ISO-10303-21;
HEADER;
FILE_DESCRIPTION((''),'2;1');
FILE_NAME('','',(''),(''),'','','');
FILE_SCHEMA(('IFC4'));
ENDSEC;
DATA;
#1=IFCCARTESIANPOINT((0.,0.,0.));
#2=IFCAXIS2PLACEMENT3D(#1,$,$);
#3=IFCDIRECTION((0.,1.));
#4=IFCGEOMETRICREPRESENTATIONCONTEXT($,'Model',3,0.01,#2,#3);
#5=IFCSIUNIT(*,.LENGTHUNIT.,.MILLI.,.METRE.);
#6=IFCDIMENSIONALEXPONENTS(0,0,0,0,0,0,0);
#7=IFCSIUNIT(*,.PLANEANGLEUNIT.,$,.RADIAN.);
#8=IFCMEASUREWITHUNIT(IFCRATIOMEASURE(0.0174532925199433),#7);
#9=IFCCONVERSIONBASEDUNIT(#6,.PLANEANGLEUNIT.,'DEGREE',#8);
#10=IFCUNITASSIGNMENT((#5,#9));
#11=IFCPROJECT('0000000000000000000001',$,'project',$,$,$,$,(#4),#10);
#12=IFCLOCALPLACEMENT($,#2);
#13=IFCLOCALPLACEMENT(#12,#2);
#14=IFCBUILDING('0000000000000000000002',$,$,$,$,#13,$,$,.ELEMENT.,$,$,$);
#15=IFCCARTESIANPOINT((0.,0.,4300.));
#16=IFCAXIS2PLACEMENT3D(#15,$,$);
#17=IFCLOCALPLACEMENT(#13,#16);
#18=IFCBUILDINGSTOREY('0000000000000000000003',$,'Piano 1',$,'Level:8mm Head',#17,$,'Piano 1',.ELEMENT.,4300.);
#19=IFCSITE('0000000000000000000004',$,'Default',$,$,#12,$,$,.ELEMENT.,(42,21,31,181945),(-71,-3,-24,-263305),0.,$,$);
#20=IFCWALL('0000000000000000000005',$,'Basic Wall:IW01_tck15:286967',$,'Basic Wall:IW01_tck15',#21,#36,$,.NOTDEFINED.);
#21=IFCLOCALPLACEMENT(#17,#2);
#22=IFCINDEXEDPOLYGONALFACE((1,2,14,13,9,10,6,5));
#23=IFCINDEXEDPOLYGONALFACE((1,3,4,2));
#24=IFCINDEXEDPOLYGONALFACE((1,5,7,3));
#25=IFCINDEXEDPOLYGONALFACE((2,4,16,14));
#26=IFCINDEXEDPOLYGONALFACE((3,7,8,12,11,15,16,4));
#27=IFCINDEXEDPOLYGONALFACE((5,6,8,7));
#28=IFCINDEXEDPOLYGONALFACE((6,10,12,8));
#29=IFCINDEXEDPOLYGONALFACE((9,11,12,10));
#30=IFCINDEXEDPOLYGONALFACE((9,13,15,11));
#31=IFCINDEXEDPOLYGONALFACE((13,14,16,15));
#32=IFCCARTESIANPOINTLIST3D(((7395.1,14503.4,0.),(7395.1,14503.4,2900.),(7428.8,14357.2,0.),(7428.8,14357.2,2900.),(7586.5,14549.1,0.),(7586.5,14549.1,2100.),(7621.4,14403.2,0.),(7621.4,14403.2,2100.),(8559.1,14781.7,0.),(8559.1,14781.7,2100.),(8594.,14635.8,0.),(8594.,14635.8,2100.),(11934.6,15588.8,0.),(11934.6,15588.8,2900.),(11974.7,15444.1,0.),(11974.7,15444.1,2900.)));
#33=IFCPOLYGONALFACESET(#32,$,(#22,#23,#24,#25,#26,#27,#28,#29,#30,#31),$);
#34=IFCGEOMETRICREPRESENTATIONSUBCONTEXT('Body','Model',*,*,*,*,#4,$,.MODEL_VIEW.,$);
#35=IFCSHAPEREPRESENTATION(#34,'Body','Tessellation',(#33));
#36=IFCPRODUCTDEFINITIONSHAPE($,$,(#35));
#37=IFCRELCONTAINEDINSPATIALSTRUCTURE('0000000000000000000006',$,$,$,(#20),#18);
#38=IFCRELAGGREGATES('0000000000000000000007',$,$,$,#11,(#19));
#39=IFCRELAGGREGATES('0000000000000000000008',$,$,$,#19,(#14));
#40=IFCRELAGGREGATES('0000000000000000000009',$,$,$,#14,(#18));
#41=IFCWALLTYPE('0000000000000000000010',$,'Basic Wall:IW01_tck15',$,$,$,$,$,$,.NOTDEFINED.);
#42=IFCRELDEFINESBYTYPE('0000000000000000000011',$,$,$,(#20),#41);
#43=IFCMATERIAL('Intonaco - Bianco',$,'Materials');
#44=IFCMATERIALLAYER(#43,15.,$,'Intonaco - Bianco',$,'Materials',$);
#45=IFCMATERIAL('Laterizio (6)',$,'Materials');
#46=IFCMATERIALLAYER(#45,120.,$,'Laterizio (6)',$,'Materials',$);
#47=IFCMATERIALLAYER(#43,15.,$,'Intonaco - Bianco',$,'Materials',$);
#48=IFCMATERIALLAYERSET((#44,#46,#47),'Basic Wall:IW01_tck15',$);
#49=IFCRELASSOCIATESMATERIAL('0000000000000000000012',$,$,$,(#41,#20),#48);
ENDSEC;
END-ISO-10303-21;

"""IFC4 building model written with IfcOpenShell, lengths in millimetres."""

from ifc_helpers import new_model, entity, si_unit, converted_unit, direction, frame, frame_2d, origin, place, context, subcontext, project, spatial, polyline, rectangle, outline, extrude, clip, bounded_halfspace, material, layer, layer_set, layer_usage, type_object, element, save


model = new_model("IFC4")

# Units and contexts
model_context = context("Model", 3, precision=0.01, world=origin(), true_north=direction((0.0, 1.0)))
body_context = subcontext(model_context, "Body", "Model", "MODEL_VIEW")
ifc_project = project(units=[si_unit("LENGTHUNIT", "METRE", prefix="MILLI"), converted_unit("PLANEANGLEUNIT", "DEGREE", entity("IfcRatioMeasure", 0.0174532925199433), si_unit("PLANEANGLEUNIT", "RADIAN"), dimensions=[0, 0, 0, 0, 0, 0, 0])], contexts=[model_context])

# Site, building, storey
site_placement = place(None, origin())
site = spatial("IfcSite", under=ifc_project, at=site_placement, Name="Default", CompositionType="ELEMENT", RefLatitude=(42, 21, 31, 181945), RefLongitude=(-71, -3, -24, -263305), RefElevation=0.0)
building_placement = place(site_placement, origin())
building = spatial("IfcBuilding", under=site, at=building_placement, CompositionType="ELEMENT")
storey_placement = place(building_placement, frame((0.0, 0.0, 4300.0)))
storey = spatial("IfcBuildingStorey", under=building, at=storey_placement, Name="Piano 1", ObjectType="Level:8mm Head", LongName="Piano 1", CompositionType="ELEMENT", Elevation=4300.0)

# Wall, opening
ifc_material_1 = material(Name="Intonaco - Bianco", Category="Materials")
ifc_layer_1 = layer(ifc_material_1, 15.0, Name="Intonaco - Bianco", Category="Materials")
ifc_material_2 = material(Name="Laterizio (6)", Category="Materials")
ifc_layer_2 = layer(ifc_material_2, 120.0, Name="Laterizio (6)", Category="Materials")
ifc_layer_3 = layer(ifc_material_1, 15.0, Name="Intonaco - Bianco", Category="Materials")
ifc_layer_set_1 = layer_set([ifc_layer_1, ifc_layer_2, ifc_layer_3], Name="Basic Wall:IW01_tck15")
wall_type_1 = type_object("IfcWallType", Name="Basic Wall:IW01_tck15", PredefinedType="NOTDEFINED", material=ifc_layer_set_1)
ifc_layer_usage_1 = layer_usage(ifc_layer_set_1, "AXIS2", "NEGATIVE", 75.0)
wall_1_placement = place(storey_placement, frame((7411.4, 14430.1, 0.0), z_axis=(0.0, 0.0, 1.0), x_axis=(0.972585, 0.232547, 0.0)))
wall_1 = element("IfcWall", 1, at=wall_1_placement, inside=storey, type_object=wall_type_1, material=ifc_layer_usage_1, Name="Basic Wall:IW01_tck15:286967", ObjectType="Basic Wall:IW01_tck15", PredefinedType="NOTDEFINED", context=body_context, shape_type="Clipping", body=[
    clip(extrude(outline(polyline([(0.0, -75.0), (1407.0, -75.0), (2257.0, -75.0), (4674.0, -75.0), (4668.6, 75.0), (2258.1, 75.0), (1408.1, 75.0), (1.2, 75.0), (0.0, -75.0)])), origin(), (0.0, 0.0, 1.0), 2900.0), bounded_halfspace(frame((0.0, -75.0, 2900.0), z_axis=(0.0, 0.0, -1.0), x_axis=(0.99922, 0.039485, 0.0)), True, frame((0.0, -75.0, 2900.0)), polyline([(0.0, 0.0), (1407.0, 0.0), (2257.0, 0.0), (4674.0, 0.0), (4668.6, 150.0), (2258.1, 150.0), (1408.1, 150.0), (1.2, 150.0), (0.0, 0.0)]))),
])
opening_1_placement = place(wall_1_placement, frame((198.0, -75.0, 0.0)))
element("IfcOpeningElement", 2, at=opening_1_placement, cuts=wall_1, ObjectType="Opening", PredefinedType="OPENING", context=body_context, shape_type="SweptSolid", body=[
    extrude(rectangle(XDim=2100.0, YDim=1000.0, at=frame_2d((1050.0, 500.0), x_axis=(1.0, 0.0))), frame((0.0, 0.0, 0.0), z_axis=(0.0, 1.0, 0.0), x_axis=(0.0, 0.0, 1.0)), (0.0, 0.0, 1.0), 150.0),
])

save(model, "model.ifc")
